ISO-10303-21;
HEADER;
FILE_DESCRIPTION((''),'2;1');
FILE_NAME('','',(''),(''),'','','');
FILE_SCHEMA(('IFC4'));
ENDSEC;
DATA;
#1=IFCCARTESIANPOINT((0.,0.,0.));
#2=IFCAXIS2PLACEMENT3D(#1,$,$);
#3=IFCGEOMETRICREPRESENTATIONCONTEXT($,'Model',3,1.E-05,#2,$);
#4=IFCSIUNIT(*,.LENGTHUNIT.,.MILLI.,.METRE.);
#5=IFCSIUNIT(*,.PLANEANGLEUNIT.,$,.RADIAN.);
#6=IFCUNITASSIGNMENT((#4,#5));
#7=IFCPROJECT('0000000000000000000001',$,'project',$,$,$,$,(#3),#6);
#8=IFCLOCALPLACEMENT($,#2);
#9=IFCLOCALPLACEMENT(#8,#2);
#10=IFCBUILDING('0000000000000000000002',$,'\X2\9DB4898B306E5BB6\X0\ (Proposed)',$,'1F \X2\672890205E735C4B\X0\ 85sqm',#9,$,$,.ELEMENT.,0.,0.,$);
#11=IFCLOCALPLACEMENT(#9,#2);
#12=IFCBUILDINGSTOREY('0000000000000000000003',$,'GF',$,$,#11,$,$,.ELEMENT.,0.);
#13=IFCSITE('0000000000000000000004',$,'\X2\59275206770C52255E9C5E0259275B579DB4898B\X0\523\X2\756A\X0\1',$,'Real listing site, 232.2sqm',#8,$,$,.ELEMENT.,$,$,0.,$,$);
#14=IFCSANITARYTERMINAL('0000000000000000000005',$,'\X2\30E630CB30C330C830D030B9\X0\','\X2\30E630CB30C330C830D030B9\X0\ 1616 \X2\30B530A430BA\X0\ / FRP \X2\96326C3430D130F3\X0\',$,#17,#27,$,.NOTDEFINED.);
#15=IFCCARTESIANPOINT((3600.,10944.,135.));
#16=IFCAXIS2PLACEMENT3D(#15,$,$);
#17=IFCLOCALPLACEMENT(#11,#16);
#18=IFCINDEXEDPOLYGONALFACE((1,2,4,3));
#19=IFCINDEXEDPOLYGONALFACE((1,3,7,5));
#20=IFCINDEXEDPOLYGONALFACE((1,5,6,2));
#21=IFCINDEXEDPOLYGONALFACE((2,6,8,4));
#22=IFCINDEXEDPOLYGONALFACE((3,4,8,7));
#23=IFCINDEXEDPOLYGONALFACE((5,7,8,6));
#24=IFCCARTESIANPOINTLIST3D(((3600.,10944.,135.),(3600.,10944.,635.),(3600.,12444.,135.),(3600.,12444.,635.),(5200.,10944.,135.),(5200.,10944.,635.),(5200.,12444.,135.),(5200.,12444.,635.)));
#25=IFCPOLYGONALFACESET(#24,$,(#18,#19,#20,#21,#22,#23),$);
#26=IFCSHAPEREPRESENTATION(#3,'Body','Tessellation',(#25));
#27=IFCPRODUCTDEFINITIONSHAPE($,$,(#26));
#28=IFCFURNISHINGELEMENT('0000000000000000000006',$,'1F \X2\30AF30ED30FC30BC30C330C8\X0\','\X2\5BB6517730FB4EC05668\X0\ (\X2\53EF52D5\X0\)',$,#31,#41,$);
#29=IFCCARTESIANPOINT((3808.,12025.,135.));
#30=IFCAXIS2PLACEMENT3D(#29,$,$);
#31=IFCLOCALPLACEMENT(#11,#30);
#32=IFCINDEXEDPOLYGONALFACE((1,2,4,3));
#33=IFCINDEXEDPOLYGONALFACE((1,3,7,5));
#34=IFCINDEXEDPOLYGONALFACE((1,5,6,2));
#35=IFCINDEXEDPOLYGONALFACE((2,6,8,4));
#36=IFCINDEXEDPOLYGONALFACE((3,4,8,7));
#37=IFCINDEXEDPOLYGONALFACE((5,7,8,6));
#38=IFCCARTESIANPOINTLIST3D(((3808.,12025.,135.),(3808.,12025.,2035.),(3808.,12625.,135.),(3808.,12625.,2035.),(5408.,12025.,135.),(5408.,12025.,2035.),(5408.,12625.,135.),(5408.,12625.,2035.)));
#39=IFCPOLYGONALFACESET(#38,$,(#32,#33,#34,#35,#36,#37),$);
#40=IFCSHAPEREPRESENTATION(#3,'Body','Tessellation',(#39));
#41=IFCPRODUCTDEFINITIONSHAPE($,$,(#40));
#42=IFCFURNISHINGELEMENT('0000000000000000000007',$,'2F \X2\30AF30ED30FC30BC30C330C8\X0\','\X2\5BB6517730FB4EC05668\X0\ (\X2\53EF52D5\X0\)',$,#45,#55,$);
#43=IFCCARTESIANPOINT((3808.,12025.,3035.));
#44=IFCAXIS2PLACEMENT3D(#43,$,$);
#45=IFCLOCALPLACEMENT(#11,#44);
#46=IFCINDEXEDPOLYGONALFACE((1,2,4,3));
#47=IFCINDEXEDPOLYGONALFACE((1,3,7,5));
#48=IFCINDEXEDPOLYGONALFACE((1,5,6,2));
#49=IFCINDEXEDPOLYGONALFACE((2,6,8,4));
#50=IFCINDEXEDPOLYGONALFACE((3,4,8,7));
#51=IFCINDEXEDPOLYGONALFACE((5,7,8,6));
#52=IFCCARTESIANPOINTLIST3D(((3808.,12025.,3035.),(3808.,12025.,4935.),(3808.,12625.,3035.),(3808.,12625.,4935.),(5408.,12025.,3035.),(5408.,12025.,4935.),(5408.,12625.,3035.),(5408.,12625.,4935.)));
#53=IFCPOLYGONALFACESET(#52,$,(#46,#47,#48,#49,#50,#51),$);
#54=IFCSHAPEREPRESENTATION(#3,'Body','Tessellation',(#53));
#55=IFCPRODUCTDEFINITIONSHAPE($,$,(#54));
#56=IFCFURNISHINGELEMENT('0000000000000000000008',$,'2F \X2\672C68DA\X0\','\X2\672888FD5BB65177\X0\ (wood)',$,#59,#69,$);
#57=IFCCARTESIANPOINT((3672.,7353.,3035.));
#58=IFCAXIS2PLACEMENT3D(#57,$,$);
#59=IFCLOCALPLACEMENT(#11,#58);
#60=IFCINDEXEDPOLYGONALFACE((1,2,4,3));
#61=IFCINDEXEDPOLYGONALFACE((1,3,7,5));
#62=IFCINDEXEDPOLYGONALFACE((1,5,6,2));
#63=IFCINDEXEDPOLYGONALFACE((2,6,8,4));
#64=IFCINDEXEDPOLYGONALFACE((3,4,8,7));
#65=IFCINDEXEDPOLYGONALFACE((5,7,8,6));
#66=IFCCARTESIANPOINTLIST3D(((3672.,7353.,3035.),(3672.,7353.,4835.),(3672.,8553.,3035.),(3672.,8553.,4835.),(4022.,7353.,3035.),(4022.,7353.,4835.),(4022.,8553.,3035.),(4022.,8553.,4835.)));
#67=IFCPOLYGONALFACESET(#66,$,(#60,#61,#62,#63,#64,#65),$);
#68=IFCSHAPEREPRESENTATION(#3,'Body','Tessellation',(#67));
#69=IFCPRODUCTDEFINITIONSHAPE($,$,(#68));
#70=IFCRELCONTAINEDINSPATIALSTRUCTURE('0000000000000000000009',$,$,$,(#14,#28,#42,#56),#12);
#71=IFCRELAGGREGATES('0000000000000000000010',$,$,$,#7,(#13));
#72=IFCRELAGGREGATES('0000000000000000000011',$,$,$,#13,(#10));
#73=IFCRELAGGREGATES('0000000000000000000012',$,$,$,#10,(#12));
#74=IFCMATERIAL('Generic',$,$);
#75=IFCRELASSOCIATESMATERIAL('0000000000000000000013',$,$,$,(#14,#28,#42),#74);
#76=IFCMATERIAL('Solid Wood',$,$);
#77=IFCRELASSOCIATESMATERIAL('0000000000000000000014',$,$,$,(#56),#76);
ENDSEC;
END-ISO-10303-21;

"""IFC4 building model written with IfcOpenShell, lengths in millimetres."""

from ifc_helpers import new_model, si_unit, frame, frame_2d, origin, place, context, project, spatial, rectangle, extrude, material, element, save


model = new_model("IFC4")

# Units and contexts
model_context = context("Model", 3, precision=1e-05, world=origin())
ifc_project = project(units=[si_unit("LENGTHUNIT", "METRE", prefix="MILLI"), si_unit("PLANEANGLEUNIT", "RADIAN")], contexts=[model_context])

# Site, building, storey
site_placement = place(None, origin())
site = spatial("IfcSite", under=ifc_project, at=site_placement, Name="大分県別府市大字鶴見523番1", ObjectType="Real listing site, 232.2sqm", CompositionType="ELEMENT", RefElevation=0.0)
building_placement = place(site_placement, origin())
building = spatial("IfcBuilding", under=site, at=building_placement, Name="鶴見の家 (Proposed)", ObjectType="1F 木造平屋 85sqm", CompositionType="ELEMENT", ElevationOfRefHeight=0.0, ElevationOfTerrain=0.0)
storey_placement = place(building_placement, origin())
storey = spatial("IfcBuildingStorey", under=building, at=storey_placement, Name="GF", CompositionType="ELEMENT", Elevation=0.0)

# Shared definitions
ifc_material_1 = material(Name="Solid Wood")

# Shared definitions
ifc_material_2 = material(Name="Generic")

# Sanitary terminal
sanitary_terminal_placement = place(storey_placement, frame((3600.0, 10944.0, 135.0)))
element("IfcSanitaryTerminal", 1, at=sanitary_terminal_placement, inside=storey, material=ifc_material_2, Name="ユニットバス", Description="ユニットバス 1616 サイズ / FRP 防水パン", PredefinedType="NOTDEFINED", context=model_context, shape_type="SweptSolid", body=[
    extrude(rectangle(XDim=1600.0, YDim=1500.0, at=frame_2d((800.0, 750.0))), frame((3600.0, 10944.0, 135.0)), (0.0, 0.0, 1.0), 500.0),
])

# Furnishing elements
furnishing_1_placement = place(storey_placement, frame((3808.0, 12025.0, 135.0)))
element("IfcFurnishingElement", 2, at=furnishing_1_placement, inside=storey, material=ifc_material_2, Name="1F クローゼット", Description="家具・什器 (可動)", context=model_context, shape_type="SweptSolid", body=[
    extrude(rectangle(XDim=1600.0, YDim=600.0, at=frame_2d((800.0, 300.0))), frame((3808.0, 12025.0, 135.0)), (0.0, 0.0, 1.0), 1900.0),
])
furnishing_2_placement = place(storey_placement, frame((3808.0, 12025.0, 3035.0)))
element("IfcFurnishingElement", 3, at=furnishing_2_placement, inside=storey, material=ifc_material_2, Name="2F クローゼット", Description="家具・什器 (可動)", context=model_context, shape_type="SweptSolid", body=[
    extrude(rectangle(XDim=1600.0, YDim=600.0, at=frame_2d((800.0, 300.0))), frame((3808.0, 12025.0, 3035.0)), (0.0, 0.0, 1.0), 1900.0),
])
furnishing_3_placement = place(storey_placement, frame((3672.0, 7353.0, 3035.0)))
element("IfcFurnishingElement", 4, at=furnishing_3_placement, inside=storey, material=ifc_material_1, Name="2F 本棚", Description="木製家具 (wood)", context=model_context, shape_type="SweptSolid", body=[
    extrude(rectangle(XDim=350.0, YDim=1200.0, at=frame_2d((175.0, 600.0))), frame((3672.0, 7353.0, 3035.0)), (0.0, 0.0, 1.0), 1800.0),
])

save(model, "model.ifc")
